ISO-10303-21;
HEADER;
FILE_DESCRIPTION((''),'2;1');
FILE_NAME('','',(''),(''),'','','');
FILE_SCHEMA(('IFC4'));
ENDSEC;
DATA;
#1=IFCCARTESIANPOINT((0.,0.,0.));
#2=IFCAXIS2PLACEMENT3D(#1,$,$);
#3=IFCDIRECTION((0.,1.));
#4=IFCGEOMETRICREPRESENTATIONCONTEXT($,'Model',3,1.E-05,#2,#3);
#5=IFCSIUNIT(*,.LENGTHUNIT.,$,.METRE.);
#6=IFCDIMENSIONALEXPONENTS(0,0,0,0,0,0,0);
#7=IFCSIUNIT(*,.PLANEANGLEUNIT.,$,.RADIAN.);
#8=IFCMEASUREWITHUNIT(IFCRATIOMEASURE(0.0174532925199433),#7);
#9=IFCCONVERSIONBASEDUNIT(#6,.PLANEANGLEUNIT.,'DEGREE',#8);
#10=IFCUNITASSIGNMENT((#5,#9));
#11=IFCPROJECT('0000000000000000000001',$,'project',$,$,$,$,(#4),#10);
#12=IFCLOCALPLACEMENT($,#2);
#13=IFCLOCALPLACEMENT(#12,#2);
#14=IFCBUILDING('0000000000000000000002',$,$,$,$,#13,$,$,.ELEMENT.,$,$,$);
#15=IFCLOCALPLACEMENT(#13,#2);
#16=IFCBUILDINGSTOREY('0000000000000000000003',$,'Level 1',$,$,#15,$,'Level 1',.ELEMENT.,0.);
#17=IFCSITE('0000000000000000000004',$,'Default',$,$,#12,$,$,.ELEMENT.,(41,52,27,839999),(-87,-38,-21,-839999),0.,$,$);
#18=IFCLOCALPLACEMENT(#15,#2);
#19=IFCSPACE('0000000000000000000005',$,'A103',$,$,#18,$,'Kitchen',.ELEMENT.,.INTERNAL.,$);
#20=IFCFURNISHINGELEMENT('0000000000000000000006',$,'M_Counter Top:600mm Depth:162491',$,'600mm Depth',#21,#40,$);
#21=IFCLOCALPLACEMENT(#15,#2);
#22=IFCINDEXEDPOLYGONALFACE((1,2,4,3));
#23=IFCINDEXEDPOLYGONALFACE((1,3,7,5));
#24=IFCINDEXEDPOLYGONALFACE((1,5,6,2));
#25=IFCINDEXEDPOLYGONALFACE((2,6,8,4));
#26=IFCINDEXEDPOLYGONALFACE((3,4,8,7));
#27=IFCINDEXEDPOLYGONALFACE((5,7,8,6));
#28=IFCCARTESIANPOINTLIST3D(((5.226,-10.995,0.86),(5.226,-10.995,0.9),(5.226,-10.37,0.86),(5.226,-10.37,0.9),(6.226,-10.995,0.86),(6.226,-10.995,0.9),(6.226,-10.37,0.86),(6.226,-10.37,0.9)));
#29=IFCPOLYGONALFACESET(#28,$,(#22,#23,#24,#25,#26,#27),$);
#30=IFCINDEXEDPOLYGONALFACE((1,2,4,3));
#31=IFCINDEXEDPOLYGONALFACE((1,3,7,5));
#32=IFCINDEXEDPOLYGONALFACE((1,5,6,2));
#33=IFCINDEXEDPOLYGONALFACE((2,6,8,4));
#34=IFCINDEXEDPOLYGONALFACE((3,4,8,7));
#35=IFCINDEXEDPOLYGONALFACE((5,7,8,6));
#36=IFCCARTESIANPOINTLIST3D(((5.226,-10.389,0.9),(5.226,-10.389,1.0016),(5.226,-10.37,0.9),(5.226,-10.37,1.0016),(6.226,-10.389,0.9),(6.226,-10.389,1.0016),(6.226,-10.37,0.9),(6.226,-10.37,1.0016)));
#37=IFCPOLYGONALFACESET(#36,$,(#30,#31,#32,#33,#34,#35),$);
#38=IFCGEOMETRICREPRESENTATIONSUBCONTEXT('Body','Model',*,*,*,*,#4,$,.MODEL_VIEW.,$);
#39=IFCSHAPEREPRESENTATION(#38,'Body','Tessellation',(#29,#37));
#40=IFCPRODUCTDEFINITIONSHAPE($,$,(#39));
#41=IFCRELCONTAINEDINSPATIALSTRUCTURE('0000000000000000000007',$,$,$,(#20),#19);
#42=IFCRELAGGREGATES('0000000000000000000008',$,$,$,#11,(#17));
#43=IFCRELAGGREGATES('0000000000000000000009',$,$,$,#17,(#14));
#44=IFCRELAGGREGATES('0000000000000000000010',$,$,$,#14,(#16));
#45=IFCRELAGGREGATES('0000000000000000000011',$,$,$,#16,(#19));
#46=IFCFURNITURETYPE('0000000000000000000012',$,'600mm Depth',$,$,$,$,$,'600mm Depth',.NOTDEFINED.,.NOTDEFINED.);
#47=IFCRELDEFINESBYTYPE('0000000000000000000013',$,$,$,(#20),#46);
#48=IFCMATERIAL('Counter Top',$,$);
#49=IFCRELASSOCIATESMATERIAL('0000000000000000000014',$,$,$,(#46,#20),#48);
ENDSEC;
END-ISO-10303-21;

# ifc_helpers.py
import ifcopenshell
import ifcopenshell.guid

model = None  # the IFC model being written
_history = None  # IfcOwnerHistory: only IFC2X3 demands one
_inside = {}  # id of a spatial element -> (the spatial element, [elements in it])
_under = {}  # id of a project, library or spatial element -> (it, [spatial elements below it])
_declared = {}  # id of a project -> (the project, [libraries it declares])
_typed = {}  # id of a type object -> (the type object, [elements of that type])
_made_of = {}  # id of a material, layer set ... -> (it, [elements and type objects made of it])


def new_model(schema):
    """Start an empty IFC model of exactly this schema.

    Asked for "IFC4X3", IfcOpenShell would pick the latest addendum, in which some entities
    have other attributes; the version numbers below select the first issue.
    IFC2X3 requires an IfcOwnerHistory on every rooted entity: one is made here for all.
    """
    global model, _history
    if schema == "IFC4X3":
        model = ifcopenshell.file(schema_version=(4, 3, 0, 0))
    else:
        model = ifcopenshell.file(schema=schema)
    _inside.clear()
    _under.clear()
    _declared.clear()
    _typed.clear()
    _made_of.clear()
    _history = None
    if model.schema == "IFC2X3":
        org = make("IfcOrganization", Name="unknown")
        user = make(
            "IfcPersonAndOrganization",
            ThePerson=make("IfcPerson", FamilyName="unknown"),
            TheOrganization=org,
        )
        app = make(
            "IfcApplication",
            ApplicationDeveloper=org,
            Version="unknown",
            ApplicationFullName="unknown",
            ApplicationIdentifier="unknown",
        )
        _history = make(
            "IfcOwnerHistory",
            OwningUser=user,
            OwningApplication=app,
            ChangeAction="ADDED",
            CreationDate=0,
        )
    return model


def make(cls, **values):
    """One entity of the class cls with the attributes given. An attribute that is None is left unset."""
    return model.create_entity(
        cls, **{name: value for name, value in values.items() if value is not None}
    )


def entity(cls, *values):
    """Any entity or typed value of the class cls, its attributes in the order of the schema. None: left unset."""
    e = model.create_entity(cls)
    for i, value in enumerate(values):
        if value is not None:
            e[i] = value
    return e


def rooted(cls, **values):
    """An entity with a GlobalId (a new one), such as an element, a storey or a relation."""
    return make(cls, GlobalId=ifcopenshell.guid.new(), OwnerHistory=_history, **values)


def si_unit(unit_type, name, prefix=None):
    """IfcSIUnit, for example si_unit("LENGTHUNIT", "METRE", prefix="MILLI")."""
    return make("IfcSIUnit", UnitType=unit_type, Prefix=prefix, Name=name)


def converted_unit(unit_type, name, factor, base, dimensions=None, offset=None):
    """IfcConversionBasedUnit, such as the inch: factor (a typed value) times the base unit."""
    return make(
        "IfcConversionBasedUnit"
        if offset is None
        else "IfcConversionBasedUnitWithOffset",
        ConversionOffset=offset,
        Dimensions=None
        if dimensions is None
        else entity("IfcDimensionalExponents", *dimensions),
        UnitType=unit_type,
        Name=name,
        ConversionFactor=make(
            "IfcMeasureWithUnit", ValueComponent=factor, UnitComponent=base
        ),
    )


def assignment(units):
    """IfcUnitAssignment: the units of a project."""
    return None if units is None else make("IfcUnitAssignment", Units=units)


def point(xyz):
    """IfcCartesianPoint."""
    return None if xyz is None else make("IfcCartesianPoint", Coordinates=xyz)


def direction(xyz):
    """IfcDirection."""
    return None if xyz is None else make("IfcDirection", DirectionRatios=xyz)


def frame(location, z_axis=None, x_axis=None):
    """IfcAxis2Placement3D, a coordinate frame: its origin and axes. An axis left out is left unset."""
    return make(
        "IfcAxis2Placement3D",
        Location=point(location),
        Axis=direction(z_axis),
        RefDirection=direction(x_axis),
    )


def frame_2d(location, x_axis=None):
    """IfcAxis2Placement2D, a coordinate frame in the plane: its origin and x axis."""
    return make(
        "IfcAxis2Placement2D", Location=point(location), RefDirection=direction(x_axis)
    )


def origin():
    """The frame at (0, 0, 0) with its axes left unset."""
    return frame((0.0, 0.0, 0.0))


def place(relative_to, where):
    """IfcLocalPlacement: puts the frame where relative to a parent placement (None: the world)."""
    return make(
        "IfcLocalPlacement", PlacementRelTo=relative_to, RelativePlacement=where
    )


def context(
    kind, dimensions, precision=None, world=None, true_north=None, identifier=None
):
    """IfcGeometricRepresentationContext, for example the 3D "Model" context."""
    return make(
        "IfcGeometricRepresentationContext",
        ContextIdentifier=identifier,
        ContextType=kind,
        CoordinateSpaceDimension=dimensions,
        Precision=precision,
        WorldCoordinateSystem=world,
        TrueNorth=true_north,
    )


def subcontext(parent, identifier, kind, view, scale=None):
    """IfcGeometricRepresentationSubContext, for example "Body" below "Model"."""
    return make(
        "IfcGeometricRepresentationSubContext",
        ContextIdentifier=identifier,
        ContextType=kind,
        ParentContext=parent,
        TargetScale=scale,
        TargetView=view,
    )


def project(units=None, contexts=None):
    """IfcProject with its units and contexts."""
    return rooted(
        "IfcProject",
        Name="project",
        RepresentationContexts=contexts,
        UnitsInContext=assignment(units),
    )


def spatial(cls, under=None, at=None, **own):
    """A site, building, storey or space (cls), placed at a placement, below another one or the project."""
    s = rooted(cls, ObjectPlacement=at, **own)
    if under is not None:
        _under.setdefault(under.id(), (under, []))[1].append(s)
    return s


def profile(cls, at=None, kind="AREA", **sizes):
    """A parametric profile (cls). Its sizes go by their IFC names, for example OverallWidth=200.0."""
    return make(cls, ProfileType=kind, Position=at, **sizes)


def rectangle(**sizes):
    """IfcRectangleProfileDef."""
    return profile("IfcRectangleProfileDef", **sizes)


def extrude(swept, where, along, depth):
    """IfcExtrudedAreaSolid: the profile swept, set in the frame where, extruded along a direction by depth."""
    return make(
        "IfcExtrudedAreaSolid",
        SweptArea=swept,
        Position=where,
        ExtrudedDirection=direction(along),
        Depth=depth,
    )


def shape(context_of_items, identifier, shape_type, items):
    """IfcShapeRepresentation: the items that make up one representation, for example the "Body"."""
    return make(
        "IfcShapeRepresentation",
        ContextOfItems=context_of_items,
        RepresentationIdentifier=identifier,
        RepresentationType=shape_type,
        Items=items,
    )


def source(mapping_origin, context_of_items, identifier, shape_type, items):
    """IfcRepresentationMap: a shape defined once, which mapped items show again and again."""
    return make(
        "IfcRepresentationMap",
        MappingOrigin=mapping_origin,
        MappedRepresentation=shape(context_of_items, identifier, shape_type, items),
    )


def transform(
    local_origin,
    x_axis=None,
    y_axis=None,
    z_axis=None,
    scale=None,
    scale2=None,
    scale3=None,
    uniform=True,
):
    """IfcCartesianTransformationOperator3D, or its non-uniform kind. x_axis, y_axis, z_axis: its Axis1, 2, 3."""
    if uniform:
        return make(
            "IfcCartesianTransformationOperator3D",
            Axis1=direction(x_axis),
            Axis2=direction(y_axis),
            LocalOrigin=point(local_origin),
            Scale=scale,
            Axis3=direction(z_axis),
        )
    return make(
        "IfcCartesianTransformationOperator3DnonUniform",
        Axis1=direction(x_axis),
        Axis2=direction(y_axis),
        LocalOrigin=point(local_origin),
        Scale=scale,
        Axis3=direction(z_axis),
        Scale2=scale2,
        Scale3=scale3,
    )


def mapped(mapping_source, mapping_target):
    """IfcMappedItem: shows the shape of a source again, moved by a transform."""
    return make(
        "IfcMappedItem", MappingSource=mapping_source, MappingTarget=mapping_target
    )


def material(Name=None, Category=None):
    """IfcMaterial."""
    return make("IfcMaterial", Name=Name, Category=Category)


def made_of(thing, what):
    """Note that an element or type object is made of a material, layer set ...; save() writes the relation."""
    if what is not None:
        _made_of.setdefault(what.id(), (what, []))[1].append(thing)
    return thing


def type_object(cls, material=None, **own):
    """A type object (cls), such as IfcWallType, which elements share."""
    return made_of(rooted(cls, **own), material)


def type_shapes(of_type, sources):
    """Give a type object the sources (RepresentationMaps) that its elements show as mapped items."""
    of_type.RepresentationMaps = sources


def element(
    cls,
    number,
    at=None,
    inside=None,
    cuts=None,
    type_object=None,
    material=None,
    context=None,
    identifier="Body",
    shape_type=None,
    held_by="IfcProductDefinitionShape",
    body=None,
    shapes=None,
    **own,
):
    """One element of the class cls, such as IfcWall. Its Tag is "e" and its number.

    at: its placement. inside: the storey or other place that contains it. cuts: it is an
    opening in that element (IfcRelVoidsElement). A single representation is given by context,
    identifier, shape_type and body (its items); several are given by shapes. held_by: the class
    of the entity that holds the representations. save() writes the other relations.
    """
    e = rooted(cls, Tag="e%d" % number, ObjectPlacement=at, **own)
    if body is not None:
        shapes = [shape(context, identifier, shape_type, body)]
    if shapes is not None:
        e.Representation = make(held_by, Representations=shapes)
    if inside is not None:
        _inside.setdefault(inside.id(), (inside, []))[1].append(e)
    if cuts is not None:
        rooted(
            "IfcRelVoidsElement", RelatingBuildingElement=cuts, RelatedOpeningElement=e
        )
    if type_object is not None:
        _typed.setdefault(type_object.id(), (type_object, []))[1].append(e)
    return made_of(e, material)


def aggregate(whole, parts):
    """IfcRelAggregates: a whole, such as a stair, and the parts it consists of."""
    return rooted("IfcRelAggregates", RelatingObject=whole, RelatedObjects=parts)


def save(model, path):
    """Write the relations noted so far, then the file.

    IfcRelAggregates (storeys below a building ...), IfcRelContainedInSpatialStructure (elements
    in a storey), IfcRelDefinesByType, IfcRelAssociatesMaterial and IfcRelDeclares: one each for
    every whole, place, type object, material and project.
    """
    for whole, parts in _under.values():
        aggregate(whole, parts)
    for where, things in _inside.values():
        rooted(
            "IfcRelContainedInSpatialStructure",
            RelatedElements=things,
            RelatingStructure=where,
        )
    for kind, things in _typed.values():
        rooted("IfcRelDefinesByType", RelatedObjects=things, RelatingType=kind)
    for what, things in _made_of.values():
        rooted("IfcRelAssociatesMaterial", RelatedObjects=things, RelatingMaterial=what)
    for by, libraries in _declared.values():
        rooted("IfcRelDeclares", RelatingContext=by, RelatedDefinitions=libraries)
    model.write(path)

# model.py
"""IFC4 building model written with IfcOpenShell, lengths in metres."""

from ifc_helpers import new_model, entity, si_unit, converted_unit, direction, frame, frame_2d, origin, place, context, subcontext, project, spatial, rectangle, extrude, source, transform, mapped, material, type_object, type_shapes, element, save


model = new_model("IFC4")

# Units and contexts
model_context = context("Model", 3, precision=1e-05, world=origin(), true_north=direction((0.0, 1.0)))
body_context = subcontext(model_context, "Body", "Model", "MODEL_VIEW")
ifc_project = project(units=[si_unit("LENGTHUNIT", "METRE"), converted_unit("PLANEANGLEUNIT", "DEGREE", entity("IfcRatioMeasure", 0.0174532925199433), si_unit("PLANEANGLEUNIT", "RADIAN"), dimensions=[0, 0, 0, 0, 0, 0, 0])], contexts=[model_context])

# Site, building, storey
site_placement = place(None, origin())
site = spatial("IfcSite", under=ifc_project, at=site_placement, Name="Default", CompositionType="ELEMENT", RefLatitude=(41, 52, 27, 839999), RefLongitude=(-87, -38, -21, -839999), RefElevation=0.0)
building_placement = place(site_placement, origin())
building = spatial("IfcBuilding", under=site, at=building_placement, CompositionType="ELEMENT")
storey_placement = place(building_placement, origin())
storey = spatial("IfcBuildingStorey", under=building, at=storey_placement, Name="Level 1", LongName="Level 1", CompositionType="ELEMENT", Elevation=0.0)

# Shared definitions
space_1_placement = place(storey_placement, origin())
space_1 = spatial("IfcSpace", under=storey, at=space_1_placement, Name="A103", LongName="Kitchen", CompositionType="ELEMENT", PredefinedType="INTERNAL")

# Furnishing element
ifc_material_1 = material(Name="Counter Top")
furniture_type_1 = type_object("IfcFurnitureType", Name="600mm Depth", ElementType="600mm Depth", AssemblyPlace="NOTDEFINED", material=ifc_material_1)
shared_shape_1 = source(origin(), body_context, "Body", "SweptSolid", [
    extrude(rectangle(XDim=1.0, YDim=0.625, at=frame_2d((0.0, 0.0), x_axis=(1.0, 0.0))), frame((-0.7005, -0.3125, 0.86), z_axis=(0.0, 0.0, 1.0), x_axis=(-1.0, 0.0, 0.0)), (0.0, 0.0, 1.0), 0.04),
    extrude(rectangle(XDim=0.0191, YDim=1.0, at=frame_2d((0.0, 0.0), x_axis=(1.0, 0.0))), frame((-0.7005, -0.0095, 0.9), z_axis=(0.0, 0.0, 1.0), x_axis=(0.0, -1.0, 0.0)), (0.0, 0.0, 1.0), 0.1016),
])
type_shapes(furniture_type_1, [shared_shape_1])
furnishing_1_placement = place(space_1_placement, frame((6.4265, -10.37, 0.0)))
element("IfcFurnishingElement", 1, at=furnishing_1_placement, inside=space_1, type_object=furniture_type_1, material=ifc_material_1, Name="M_Counter Top:600mm Depth:162491", ObjectType="600mm Depth", context=body_context, shape_type="MappedRepresentation", body=[
    mapped(shared_shape_1, transform((0.0, 0.0, 0.0), scale=1.0)),
])

save(model, "model.ifc")
